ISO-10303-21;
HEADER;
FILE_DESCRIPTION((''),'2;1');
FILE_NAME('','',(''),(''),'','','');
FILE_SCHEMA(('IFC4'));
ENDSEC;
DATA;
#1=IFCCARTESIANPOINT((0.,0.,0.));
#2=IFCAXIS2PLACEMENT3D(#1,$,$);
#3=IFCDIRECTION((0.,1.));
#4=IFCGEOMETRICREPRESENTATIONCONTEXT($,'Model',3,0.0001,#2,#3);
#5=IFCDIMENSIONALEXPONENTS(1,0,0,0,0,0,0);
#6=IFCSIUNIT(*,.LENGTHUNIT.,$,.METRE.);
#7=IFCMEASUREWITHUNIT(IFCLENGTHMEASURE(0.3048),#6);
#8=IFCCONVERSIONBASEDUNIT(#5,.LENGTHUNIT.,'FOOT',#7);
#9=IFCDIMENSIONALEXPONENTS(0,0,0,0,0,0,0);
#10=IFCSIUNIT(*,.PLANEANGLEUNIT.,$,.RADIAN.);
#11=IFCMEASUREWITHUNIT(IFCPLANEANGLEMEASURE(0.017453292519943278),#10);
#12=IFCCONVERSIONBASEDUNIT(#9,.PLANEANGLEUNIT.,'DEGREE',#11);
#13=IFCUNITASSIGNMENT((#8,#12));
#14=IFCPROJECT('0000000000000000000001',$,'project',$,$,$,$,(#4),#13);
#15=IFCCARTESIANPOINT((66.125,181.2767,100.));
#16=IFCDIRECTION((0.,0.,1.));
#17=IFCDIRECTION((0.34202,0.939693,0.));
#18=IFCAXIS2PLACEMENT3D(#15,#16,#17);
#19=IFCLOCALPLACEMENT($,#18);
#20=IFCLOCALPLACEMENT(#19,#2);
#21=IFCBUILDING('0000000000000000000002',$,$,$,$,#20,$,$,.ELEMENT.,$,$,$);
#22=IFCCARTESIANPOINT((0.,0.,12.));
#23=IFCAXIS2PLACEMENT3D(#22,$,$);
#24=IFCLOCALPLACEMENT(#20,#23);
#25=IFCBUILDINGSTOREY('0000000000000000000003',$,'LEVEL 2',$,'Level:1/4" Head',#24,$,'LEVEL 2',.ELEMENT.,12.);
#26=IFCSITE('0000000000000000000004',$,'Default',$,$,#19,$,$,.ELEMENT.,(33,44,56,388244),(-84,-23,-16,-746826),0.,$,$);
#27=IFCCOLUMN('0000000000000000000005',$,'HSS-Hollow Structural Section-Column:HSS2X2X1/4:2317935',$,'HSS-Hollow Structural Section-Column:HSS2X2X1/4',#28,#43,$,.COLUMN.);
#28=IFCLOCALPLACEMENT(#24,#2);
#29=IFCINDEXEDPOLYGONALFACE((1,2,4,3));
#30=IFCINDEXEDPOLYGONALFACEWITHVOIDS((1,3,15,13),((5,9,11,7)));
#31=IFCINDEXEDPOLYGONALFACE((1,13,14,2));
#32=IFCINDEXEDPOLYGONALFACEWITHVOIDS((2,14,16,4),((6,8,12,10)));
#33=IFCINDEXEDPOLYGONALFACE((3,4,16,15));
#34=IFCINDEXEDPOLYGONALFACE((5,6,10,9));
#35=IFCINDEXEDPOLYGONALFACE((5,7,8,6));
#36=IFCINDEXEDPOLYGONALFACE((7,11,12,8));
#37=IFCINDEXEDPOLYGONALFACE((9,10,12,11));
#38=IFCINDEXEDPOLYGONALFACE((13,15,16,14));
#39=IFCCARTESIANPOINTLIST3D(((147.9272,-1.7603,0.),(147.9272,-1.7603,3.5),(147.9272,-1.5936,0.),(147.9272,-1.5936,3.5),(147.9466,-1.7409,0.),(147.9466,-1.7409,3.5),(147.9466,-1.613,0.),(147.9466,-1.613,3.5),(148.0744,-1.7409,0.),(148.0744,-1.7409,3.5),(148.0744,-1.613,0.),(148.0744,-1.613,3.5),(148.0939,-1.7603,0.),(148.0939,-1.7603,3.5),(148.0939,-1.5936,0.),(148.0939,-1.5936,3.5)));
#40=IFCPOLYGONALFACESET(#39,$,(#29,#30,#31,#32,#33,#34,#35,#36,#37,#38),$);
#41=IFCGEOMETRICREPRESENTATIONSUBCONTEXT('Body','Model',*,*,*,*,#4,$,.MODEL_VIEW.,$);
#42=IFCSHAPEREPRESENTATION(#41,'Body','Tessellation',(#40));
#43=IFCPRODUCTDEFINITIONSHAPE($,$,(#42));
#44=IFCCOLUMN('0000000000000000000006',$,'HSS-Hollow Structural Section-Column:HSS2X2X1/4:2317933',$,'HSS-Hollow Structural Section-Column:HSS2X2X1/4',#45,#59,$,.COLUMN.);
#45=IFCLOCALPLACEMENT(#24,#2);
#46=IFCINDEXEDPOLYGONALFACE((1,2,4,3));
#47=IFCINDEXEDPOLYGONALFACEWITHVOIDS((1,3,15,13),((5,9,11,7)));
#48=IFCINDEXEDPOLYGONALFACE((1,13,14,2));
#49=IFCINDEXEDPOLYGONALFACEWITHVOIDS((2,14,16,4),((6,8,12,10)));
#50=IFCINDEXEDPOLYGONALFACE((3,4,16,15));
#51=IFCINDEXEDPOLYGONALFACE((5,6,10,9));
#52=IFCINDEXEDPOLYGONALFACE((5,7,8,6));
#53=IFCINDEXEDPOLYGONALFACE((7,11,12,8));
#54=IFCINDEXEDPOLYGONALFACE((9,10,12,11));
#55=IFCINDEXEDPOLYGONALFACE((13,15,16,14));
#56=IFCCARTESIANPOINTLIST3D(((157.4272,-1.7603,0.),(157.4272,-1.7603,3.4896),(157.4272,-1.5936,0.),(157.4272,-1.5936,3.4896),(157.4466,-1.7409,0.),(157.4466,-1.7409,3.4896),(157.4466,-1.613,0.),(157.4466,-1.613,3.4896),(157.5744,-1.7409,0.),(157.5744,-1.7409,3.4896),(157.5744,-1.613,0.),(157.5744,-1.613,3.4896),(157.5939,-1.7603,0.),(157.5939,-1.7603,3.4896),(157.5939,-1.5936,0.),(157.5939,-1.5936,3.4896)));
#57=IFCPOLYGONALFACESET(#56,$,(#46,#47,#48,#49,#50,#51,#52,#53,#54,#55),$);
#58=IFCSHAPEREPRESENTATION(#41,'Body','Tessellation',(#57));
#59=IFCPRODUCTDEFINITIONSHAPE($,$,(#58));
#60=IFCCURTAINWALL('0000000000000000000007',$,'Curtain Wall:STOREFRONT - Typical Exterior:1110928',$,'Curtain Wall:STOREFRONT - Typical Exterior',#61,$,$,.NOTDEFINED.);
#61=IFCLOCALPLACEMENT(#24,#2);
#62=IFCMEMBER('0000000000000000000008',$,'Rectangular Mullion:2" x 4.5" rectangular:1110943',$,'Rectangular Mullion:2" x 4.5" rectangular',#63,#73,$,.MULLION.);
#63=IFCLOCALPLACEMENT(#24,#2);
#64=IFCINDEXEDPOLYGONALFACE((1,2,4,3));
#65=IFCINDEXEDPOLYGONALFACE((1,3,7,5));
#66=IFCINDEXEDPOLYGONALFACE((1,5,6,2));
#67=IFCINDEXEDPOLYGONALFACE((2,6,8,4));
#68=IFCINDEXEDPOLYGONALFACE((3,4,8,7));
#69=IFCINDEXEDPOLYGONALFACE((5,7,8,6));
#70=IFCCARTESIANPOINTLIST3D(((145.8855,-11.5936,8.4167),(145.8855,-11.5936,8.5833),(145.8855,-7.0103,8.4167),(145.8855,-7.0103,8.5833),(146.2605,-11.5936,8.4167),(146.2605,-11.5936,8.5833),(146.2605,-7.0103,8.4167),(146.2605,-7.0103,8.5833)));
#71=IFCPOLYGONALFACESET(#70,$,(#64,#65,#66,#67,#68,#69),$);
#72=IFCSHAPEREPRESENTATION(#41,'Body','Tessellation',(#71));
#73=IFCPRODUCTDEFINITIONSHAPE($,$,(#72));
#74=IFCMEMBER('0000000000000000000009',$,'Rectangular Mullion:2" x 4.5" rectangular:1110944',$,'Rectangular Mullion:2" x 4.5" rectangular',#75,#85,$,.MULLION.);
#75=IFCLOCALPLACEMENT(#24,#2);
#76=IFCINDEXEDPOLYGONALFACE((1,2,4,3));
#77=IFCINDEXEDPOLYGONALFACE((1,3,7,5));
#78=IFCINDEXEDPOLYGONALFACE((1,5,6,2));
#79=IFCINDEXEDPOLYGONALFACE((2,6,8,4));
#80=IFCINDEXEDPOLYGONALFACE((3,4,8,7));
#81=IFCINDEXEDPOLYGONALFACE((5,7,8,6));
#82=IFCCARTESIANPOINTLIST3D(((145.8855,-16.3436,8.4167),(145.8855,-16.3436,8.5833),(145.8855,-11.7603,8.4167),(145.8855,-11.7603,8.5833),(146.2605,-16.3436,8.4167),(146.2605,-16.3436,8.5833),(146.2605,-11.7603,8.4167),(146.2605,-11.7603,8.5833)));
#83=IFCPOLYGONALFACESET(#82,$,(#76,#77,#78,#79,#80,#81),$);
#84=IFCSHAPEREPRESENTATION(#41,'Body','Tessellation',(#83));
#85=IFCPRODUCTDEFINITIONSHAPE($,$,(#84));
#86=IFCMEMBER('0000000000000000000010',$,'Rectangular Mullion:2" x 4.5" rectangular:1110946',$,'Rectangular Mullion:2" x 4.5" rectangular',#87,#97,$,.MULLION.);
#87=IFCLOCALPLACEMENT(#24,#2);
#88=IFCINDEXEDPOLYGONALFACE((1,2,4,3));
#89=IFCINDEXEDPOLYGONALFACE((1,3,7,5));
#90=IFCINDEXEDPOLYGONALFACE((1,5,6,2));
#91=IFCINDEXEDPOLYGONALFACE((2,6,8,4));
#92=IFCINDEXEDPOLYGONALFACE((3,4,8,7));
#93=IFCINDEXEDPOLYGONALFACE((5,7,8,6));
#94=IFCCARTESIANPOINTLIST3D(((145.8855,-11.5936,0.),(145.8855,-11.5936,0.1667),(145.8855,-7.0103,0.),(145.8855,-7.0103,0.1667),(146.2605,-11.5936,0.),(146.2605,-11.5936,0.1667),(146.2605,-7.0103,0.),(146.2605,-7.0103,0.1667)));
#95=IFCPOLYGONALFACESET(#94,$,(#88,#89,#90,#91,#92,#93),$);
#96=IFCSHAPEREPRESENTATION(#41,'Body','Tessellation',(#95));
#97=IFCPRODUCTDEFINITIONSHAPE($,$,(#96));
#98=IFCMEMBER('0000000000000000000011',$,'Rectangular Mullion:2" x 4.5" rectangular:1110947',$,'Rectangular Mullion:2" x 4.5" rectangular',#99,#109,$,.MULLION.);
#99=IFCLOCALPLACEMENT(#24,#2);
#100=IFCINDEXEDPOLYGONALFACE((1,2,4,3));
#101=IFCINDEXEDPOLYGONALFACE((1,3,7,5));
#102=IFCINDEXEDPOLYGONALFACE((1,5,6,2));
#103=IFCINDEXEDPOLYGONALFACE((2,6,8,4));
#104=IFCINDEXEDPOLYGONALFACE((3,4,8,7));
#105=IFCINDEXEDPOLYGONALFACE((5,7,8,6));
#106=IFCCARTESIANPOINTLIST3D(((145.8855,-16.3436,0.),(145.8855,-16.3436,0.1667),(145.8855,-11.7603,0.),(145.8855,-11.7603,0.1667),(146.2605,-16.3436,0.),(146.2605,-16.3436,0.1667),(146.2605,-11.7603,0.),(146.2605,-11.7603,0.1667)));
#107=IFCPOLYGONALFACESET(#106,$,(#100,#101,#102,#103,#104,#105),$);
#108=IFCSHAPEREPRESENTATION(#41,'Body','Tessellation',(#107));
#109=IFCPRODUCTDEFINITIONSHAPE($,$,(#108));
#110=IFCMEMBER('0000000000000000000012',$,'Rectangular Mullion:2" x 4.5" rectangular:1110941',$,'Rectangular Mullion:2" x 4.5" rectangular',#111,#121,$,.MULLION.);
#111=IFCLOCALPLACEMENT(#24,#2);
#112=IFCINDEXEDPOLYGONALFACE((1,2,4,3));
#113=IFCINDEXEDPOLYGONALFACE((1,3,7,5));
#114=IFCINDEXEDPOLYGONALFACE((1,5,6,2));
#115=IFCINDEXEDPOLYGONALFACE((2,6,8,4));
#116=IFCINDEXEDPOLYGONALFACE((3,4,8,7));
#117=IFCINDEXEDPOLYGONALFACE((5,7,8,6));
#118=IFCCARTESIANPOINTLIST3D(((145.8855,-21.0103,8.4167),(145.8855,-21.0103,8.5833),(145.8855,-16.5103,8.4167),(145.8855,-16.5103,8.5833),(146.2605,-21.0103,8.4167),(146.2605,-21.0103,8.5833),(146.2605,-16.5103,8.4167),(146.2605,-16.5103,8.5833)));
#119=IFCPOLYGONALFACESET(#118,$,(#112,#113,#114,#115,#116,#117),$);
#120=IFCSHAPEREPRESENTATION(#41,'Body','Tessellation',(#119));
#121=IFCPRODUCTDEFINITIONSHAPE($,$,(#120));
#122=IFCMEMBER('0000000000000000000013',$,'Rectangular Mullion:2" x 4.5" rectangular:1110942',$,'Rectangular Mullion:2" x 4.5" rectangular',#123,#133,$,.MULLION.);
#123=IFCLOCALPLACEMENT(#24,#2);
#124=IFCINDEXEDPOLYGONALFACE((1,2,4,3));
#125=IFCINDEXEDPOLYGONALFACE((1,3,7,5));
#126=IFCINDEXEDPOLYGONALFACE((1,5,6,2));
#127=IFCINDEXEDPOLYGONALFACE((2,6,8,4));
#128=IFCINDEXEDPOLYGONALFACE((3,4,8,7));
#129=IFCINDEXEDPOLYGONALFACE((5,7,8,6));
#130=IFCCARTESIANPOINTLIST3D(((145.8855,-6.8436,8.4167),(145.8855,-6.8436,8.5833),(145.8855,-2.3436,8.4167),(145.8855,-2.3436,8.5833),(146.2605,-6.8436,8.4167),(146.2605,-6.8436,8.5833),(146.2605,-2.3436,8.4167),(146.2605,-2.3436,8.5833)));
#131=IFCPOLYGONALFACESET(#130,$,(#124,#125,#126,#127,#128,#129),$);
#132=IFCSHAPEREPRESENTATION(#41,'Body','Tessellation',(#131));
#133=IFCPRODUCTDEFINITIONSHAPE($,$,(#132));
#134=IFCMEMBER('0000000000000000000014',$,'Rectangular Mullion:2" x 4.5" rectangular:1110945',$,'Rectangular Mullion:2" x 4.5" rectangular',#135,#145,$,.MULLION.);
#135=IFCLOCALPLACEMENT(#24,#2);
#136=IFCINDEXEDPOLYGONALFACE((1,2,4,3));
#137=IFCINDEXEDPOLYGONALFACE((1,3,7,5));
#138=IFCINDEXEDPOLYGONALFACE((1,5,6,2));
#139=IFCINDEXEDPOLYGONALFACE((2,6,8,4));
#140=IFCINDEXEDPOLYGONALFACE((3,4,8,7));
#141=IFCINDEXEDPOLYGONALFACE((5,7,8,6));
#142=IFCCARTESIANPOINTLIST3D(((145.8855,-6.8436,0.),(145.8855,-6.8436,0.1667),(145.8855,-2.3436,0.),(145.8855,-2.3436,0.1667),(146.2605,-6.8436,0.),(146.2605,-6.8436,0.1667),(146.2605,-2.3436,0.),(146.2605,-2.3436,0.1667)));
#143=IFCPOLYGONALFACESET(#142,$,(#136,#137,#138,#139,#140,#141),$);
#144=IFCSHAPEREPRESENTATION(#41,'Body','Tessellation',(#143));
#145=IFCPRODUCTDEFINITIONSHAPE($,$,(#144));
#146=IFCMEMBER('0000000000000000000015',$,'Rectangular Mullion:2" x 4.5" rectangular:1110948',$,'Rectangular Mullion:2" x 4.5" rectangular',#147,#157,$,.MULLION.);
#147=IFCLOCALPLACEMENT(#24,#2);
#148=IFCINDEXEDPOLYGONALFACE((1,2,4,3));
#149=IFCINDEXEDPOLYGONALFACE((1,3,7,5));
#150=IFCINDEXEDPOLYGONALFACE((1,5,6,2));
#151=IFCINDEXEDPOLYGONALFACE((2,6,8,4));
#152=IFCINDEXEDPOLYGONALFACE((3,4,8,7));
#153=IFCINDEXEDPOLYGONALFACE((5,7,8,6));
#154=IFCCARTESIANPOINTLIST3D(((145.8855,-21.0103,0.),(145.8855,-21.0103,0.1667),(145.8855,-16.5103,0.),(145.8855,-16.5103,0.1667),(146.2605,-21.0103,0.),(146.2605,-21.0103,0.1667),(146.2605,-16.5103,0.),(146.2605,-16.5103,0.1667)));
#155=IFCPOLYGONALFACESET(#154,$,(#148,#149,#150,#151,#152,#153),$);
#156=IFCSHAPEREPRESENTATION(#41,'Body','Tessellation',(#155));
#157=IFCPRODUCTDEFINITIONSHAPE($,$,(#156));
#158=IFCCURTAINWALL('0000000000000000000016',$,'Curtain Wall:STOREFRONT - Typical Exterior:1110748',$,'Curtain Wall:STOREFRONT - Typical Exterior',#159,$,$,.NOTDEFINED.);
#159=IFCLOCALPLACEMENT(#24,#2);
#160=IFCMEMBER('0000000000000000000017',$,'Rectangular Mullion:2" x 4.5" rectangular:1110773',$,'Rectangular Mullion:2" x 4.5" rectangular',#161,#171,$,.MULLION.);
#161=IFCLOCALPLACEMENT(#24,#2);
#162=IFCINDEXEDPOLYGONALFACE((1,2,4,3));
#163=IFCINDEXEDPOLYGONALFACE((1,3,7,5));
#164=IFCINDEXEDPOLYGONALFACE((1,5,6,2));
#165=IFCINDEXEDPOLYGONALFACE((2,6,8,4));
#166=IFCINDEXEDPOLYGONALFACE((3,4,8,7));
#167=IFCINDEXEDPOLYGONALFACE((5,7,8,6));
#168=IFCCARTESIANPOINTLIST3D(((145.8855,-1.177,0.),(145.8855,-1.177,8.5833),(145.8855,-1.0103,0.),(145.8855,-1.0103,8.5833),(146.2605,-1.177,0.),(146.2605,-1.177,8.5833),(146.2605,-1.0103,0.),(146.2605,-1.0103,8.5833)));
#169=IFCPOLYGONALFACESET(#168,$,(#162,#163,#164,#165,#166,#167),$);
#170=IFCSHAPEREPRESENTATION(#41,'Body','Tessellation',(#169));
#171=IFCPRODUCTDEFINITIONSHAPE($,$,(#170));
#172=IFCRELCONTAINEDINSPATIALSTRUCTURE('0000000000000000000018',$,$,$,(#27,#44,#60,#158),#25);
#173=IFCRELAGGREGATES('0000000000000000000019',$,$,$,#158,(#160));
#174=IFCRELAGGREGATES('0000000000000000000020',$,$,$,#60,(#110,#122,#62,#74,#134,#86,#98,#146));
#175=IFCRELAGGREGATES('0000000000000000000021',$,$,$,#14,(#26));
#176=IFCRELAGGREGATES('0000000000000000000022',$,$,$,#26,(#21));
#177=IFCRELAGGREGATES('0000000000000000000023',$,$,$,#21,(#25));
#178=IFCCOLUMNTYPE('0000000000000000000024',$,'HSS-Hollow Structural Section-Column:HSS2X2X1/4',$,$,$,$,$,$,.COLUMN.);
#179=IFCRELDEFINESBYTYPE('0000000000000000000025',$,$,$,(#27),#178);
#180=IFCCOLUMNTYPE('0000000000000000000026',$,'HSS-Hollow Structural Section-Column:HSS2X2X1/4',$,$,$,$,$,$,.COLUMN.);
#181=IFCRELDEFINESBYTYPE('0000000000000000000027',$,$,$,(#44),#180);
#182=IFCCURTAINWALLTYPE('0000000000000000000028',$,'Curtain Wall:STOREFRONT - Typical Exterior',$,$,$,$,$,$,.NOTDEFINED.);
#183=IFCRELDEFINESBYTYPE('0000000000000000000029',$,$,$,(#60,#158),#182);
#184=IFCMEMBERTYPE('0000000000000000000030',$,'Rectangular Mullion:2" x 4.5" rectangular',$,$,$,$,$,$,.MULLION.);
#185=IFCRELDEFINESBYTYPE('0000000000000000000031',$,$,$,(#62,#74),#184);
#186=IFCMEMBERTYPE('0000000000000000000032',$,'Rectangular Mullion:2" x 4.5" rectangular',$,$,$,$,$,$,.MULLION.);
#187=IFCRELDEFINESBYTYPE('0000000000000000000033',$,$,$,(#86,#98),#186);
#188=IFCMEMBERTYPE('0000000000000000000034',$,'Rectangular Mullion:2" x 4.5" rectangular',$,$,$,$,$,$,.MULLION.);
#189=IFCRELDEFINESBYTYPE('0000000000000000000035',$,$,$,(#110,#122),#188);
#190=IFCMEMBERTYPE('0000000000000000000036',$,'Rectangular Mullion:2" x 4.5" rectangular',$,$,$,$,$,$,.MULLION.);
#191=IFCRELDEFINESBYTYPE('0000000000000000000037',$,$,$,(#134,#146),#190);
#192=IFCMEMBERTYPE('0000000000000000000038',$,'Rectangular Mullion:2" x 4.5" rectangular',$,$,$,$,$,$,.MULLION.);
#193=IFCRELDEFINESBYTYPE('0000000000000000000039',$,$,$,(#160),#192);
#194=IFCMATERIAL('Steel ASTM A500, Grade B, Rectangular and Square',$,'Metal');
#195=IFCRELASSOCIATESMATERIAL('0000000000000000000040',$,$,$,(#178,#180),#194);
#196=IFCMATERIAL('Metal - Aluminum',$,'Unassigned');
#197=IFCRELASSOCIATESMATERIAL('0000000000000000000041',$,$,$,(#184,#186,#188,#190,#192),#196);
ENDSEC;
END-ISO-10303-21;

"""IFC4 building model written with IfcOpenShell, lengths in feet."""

from ifc_helpers import new_model, entity, si_unit, converted_unit, direction, frame, origin, origin_2d_with_axis, place, context, subcontext, project, spatial, polyline, rectangle, outline, extrude, source, transform, mapped, material, material_profile, profile_set, type_object, type_shapes, element, aggregate, save


model = new_model("IFC4")

# Units and contexts
model_context = context("Model", 3, precision=0.0001, world=origin(), true_north=direction((0.0, 1.0)))
body_context = subcontext(model_context, "Body", "Model", "MODEL_VIEW")
ifc_project = project(units=[converted_unit("LENGTHUNIT", "FOOT", entity("IfcLengthMeasure", 0.3048), si_unit("LENGTHUNIT", "METRE"), dimensions=[1, 0, 0, 0, 0, 0, 0]), converted_unit("PLANEANGLEUNIT", "DEGREE", entity("IfcPlaneAngleMeasure", 0.017453292519943278), si_unit("PLANEANGLEUNIT", "RADIAN"), dimensions=[0, 0, 0, 0, 0, 0, 0])], contexts=[model_context])

# Site, building, storey
site_placement = place(None, frame((66.125, 181.2767, 100.0), z_axis=(0.0, 0.0, 1.0), x_axis=(0.34202, 0.939693, 0.0)))
site = spatial("IfcSite", under=ifc_project, at=site_placement, Name="Default", CompositionType="ELEMENT", RefLatitude=(33, 44, 56, 388244), RefLongitude=(-84, -23, -16, -746826), RefElevation=0.0)
building_placement = place(site_placement, origin())
building = spatial("IfcBuilding", under=site, at=building_placement, CompositionType="ELEMENT")
storey_placement = place(building_placement, frame((0.0, 0.0, 12.0)))
storey = spatial("IfcBuildingStorey", under=building, at=storey_placement, Name="LEVEL 2", ObjectType="Level:1/4\" Head", LongName="LEVEL 2", CompositionType="ELEMENT", Elevation=12.0)

# Columns
ifc_material_1 = material(Name="Steel ASTM A500, Grade B, Rectangular and Square", Category="Metal")
ifc_material_profile_1 = material_profile(ifc_material_1, outline(polyline([(-0.0833, -0.0833), (0.0833, -0.0833), (0.0833, 0.0833), (-0.0833, 0.0833), (-0.0833, -0.0833)]), holes=[polyline([(-0.0639, -0.0639), (-0.0639, 0.0639), (0.0639, 0.0639), (0.0639, -0.0639), (-0.0639, -0.0639)])]), Name="HSS2X2X1/4")
ifc_profile_set_1 = profile_set([ifc_material_profile_1], Name="HSS2X2X1/4")
column_type_1 = type_object("IfcColumnType", Name="HSS-Hollow Structural Section-Column:HSS2X2X1/4", PredefinedType="COLUMN", material=ifc_profile_set_1)
shared_shape_1 = source(origin(), body_context, "Body", "SweptSolid", [
    extrude(outline(polyline([(-0.0833, -0.0833), (0.0833, -0.0833), (0.0833, 0.0833), (-0.0833, 0.0833), (-0.0833, -0.0833)]), holes=[polyline([(-0.0639, -0.0639), (-0.0639, 0.0639), (0.0639, 0.0639), (0.0639, -0.0639), (-0.0639, -0.0639)])]), frame((0.0, 0.0, 12.0), z_axis=(0.0, 0.0, 1.0), x_axis=(-1.0, 0.0, 0.0)), (0.0, 0.0, 1.0), 3.5),
])
type_shapes(column_type_1, [shared_shape_1])
column_1_placement = place(storey_placement, frame((148.0105, -1.677, -12.0)))
element("IfcColumn", 1, at=column_1_placement, inside=storey, type_object=column_type_1, Name="HSS-Hollow Structural Section-Column:HSS2X2X1/4:2317935", ObjectType="HSS-Hollow Structural Section-Column:HSS2X2X1/4", PredefinedType="COLUMN", context=body_context, shape_type="MappedRepresentation", body=[
    mapped(shared_shape_1, transform((0.0, 0.0, 0.0), scale=1.0)),
])
column_type_2 = type_object("IfcColumnType", Name="HSS-Hollow Structural Section-Column:HSS2X2X1/4", PredefinedType="COLUMN", material=ifc_profile_set_1)
shared_shape_2 = source(origin(), body_context, "Body", "SweptSolid", [
    extrude(outline(polyline([(-0.0833, -0.0833), (0.0833, -0.0833), (0.0833, 0.0833), (-0.0833, 0.0833), (-0.0833, -0.0833)]), holes=[polyline([(-0.0639, -0.0639), (-0.0639, 0.0639), (0.0639, 0.0639), (0.0639, -0.0639), (-0.0639, -0.0639)])]), frame((0.0, 0.0, 12.0), z_axis=(0.0, 0.0, 1.0), x_axis=(-1.0, 0.0, 0.0)), (0.0, 0.0, 1.0), 3.4896),
])
type_shapes(column_type_2, [shared_shape_2])
column_2_placement = place(storey_placement, frame((157.5105, -1.677, -12.0)))
element("IfcColumn", 2, at=column_2_placement, inside=storey, type_object=column_type_2, Name="HSS-Hollow Structural Section-Column:HSS2X2X1/4:2317933", ObjectType="HSS-Hollow Structural Section-Column:HSS2X2X1/4", PredefinedType="COLUMN", context=body_context, shape_type="MappedRepresentation", body=[
    mapped(shared_shape_2, transform((0.0, 0.0, 0.0), scale=1.0)),
])

# Curtain wall, members
curtain_wall_type = type_object("IfcCurtainWallType", Name="Curtain Wall:STOREFRONT - Typical Exterior", PredefinedType="NOTDEFINED")
curtain_wall_1_placement = place(storey_placement, frame((0.0, 0.0, -12.0)))
curtain_wall_1 = element("IfcCurtainWall", 3, at=curtain_wall_1_placement, inside=storey, type_object=curtain_wall_type, Name="Curtain Wall:STOREFRONT - Typical Exterior:1110928", ObjectType="Curtain Wall:STOREFRONT - Typical Exterior", PredefinedType="NOTDEFINED")
ifc_material_2 = material(Name="Metal - Aluminum", Category="Unassigned")
ifc_material_profile_2 = material_profile(ifc_material_2, rectangle(XDim=0.1667, YDim=0.375, at=origin_2d_with_axis()), Name="2\" x 4.5\" rectangular")
ifc_profile_set_2 = profile_set([ifc_material_profile_2], Name="2\" x 4.5\" rectangular")
member_type_1 = type_object("IfcMemberType", Name="Rectangular Mullion:2\" x 4.5\" rectangular", PredefinedType="MULLION", material=ifc_profile_set_2)
shared_shape_3 = source(origin(), body_context, "Body", "SweptSolid", [
    extrude(rectangle(XDim=0.1667, YDim=0.375, at=origin_2d_with_axis()), frame((-0.0833, 0.0, -4.5833), z_axis=(0.0, 0.0, 1.0), x_axis=(-1.0, 0.0, 0.0)), (0.0, 0.0, 1.0), 4.5833),
])
type_shapes(member_type_1, [shared_shape_3])
member_1_placement = place(curtain_wall_1_placement, frame((146.073, -11.5936, 20.5833), z_axis=(0.0, -1.0, 0.0), x_axis=(0.0, 0.0, 1.0)))
member_1 = element("IfcMember", 4, at=member_1_placement, type_object=member_type_1, Name="Rectangular Mullion:2\" x 4.5\" rectangular:1110943", ObjectType="Rectangular Mullion:2\" x 4.5\" rectangular", PredefinedType="MULLION", context=body_context, shape_type="MappedRepresentation", body=[
    mapped(shared_shape_3, transform((0.0, 0.0, 0.0), scale=1.0)),
])
member_2_placement = place(curtain_wall_1_placement, frame((146.073, -16.3436, 20.5833), z_axis=(0.0, -1.0, 0.0), x_axis=(0.0, 0.0, 1.0)))
member_2 = element("IfcMember", 5, at=member_2_placement, type_object=member_type_1, Name="Rectangular Mullion:2\" x 4.5\" rectangular:1110944", ObjectType="Rectangular Mullion:2\" x 4.5\" rectangular", PredefinedType="MULLION", context=body_context, shape_type="MappedRepresentation", body=[
    mapped(shared_shape_3, transform((0.0, 0.0, 0.0), scale=1.0)),
])
member_type_2 = type_object("IfcMemberType", Name="Rectangular Mullion:2\" x 4.5\" rectangular", PredefinedType="MULLION", material=ifc_profile_set_2)
shared_shape_4 = source(origin(), body_context, "Body", "SweptSolid", [
    extrude(rectangle(XDim=0.1667, YDim=0.375, at=origin_2d_with_axis()), frame((-0.0833, 0.0, -4.5833), z_axis=(0.0, 0.0, 1.0), x_axis=(-1.0, 0.0, 0.0)), (0.0, 0.0, 1.0), 4.5833),
])
type_shapes(member_type_2, [shared_shape_4])
member_3_placement = place(curtain_wall_1_placement, frame((146.073, -7.0103, 12.0), z_axis=(0.0, 1.0, 0.0), x_axis=(0.0, 0.0, -1.0)))
member_3 = element("IfcMember", 6, at=member_3_placement, type_object=member_type_2, Name="Rectangular Mullion:2\" x 4.5\" rectangular:1110946", ObjectType="Rectangular Mullion:2\" x 4.5\" rectangular", PredefinedType="MULLION", context=body_context, shape_type="MappedRepresentation", body=[
    mapped(shared_shape_4, transform((0.0, 0.0, 0.0), scale=1.0)),
])
member_4_placement = place(curtain_wall_1_placement, frame((146.073, -11.7603, 12.0), z_axis=(0.0, 1.0, 0.0), x_axis=(0.0, 0.0, -1.0)))
member_4 = element("IfcMember", 7, at=member_4_placement, type_object=member_type_2, Name="Rectangular Mullion:2\" x 4.5\" rectangular:1110947", ObjectType="Rectangular Mullion:2\" x 4.5\" rectangular", PredefinedType="MULLION", context=body_context, shape_type="MappedRepresentation", body=[
    mapped(shared_shape_4, transform((0.0, 0.0, 0.0), scale=1.0)),
])
member_type_3 = type_object("IfcMemberType", Name="Rectangular Mullion:2\" x 4.5\" rectangular", PredefinedType="MULLION", material=ifc_profile_set_2)
shared_shape_5 = source(origin(), body_context, "Body", "SweptSolid", [
    extrude(rectangle(XDim=0.1667, YDim=0.375, at=origin_2d_with_axis()), frame((-0.0833, 0.0, -4.5), z_axis=(0.0, 0.0, 1.0), x_axis=(-1.0, 0.0, 0.0)), (0.0, 0.0, 1.0), 4.5),
])
type_shapes(member_type_3, [shared_shape_5])
member_5_placement = place(curtain_wall_1_placement, frame((146.073, -21.0103, 20.5833), z_axis=(0.0, -1.0, 0.0), x_axis=(0.0, 0.0, 1.0)))
member_5 = element("IfcMember", 8, at=member_5_placement, type_object=member_type_3, Name="Rectangular Mullion:2\" x 4.5\" rectangular:1110941", ObjectType="Rectangular Mullion:2\" x 4.5\" rectangular", PredefinedType="MULLION", context=body_context, shape_type="MappedRepresentation", body=[
    mapped(shared_shape_5, transform((0.0, 0.0, 0.0), scale=1.0)),
])
member_6_placement = place(curtain_wall_1_placement, frame((146.073, -6.8436, 20.5833), z_axis=(0.0, -1.0, 0.0), x_axis=(0.0, 0.0, 1.0)))
member_6 = element("IfcMember", 9, at=member_6_placement, type_object=member_type_3, Name="Rectangular Mullion:2\" x 4.5\" rectangular:1110942", ObjectType="Rectangular Mullion:2\" x 4.5\" rectangular", PredefinedType="MULLION", context=body_context, shape_type="MappedRepresentation", body=[
    mapped(shared_shape_5, transform((0.0, 0.0, 0.0), scale=1.0)),
])
member_type_4 = type_object("IfcMemberType", Name="Rectangular Mullion:2\" x 4.5\" rectangular", PredefinedType="MULLION", material=ifc_profile_set_2)
shared_shape_6 = source(origin(), body_context, "Body", "SweptSolid", [
    extrude(rectangle(XDim=0.1667, YDim=0.375, at=origin_2d_with_axis()), frame((-0.0833, 0.0, -4.5), z_axis=(0.0, 0.0, 1.0), x_axis=(-1.0, 0.0, 0.0)), (0.0, 0.0, 1.0), 4.5),
])
type_shapes(member_type_4, [shared_shape_6])
member_7_placement = place(curtain_wall_1_placement, frame((146.073, -2.3436, 12.0), z_axis=(0.0, 1.0, 0.0), x_axis=(0.0, 0.0, -1.0)))
member_7 = element("IfcMember", 10, at=member_7_placement, type_object=member_type_4, Name="Rectangular Mullion:2\" x 4.5\" rectangular:1110945", ObjectType="Rectangular Mullion:2\" x 4.5\" rectangular", PredefinedType="MULLION", context=body_context, shape_type="MappedRepresentation", body=[
    mapped(shared_shape_6, transform((0.0, 0.0, 0.0), scale=1.0)),
])
member_8_placement = place(curtain_wall_1_placement, frame((146.073, -16.5103, 12.0), z_axis=(0.0, 1.0, 0.0), x_axis=(0.0, 0.0, -1.0)))
member_8 = element("IfcMember", 11, at=member_8_placement, type_object=member_type_4, Name="Rectangular Mullion:2\" x 4.5\" rectangular:1110948", ObjectType="Rectangular Mullion:2\" x 4.5\" rectangular", PredefinedType="MULLION", context=body_context, shape_type="MappedRepresentation", body=[
    mapped(shared_shape_6, transform((0.0, 0.0, 0.0), scale=1.0)),
])

# Curtain wall, member
curtain_wall_2_placement = place(storey_placement, frame((0.0, 0.0, -12.0)))
curtain_wall_2 = element("IfcCurtainWall", 12, at=curtain_wall_2_placement, inside=storey, type_object=curtain_wall_type, Name="Curtain Wall:STOREFRONT - Typical Exterior:1110748", ObjectType="Curtain Wall:STOREFRONT - Typical Exterior", PredefinedType="NOTDEFINED")
member_type_5 = type_object("IfcMemberType", Name="Rectangular Mullion:2\" x 4.5\" rectangular", PredefinedType="MULLION", material=ifc_profile_set_2)
shared_shape_7 = source(origin(), body_context, "Body", "SweptSolid", [
    extrude(rectangle(XDim=0.1667, YDim=0.375, at=origin_2d_with_axis()), frame((-0.0833, 0.0, -8.5833), z_axis=(0.0, 0.0, 1.0), x_axis=(-1.0, 0.0, 0.0)), (0.0, 0.0, 1.0), 8.5833),
])
type_shapes(member_type_5, [shared_shape_7])
member_9_placement = place(curtain_wall_2_placement, frame((146.073, -1.177, 12.0), z_axis=(0.0, 0.0, -1.0), x_axis=(0.0, -1.0, 0.0)))
member_9 = element("IfcMember", 13, at=member_9_placement, type_object=member_type_5, Name="Rectangular Mullion:2\" x 4.5\" rectangular:1110773", ObjectType="Rectangular Mullion:2\" x 4.5\" rectangular", PredefinedType="MULLION", context=body_context, shape_type="MappedRepresentation", body=[
    mapped(shared_shape_7, transform((0.0, 0.0, 0.0), scale=1.0)),
])
aggregate(curtain_wall_2, [member_9])

aggregate(curtain_wall_1, [member_5, member_6, member_1, member_2, member_7, member_3, member_4, member_8])

save(model, "model.ifc")
